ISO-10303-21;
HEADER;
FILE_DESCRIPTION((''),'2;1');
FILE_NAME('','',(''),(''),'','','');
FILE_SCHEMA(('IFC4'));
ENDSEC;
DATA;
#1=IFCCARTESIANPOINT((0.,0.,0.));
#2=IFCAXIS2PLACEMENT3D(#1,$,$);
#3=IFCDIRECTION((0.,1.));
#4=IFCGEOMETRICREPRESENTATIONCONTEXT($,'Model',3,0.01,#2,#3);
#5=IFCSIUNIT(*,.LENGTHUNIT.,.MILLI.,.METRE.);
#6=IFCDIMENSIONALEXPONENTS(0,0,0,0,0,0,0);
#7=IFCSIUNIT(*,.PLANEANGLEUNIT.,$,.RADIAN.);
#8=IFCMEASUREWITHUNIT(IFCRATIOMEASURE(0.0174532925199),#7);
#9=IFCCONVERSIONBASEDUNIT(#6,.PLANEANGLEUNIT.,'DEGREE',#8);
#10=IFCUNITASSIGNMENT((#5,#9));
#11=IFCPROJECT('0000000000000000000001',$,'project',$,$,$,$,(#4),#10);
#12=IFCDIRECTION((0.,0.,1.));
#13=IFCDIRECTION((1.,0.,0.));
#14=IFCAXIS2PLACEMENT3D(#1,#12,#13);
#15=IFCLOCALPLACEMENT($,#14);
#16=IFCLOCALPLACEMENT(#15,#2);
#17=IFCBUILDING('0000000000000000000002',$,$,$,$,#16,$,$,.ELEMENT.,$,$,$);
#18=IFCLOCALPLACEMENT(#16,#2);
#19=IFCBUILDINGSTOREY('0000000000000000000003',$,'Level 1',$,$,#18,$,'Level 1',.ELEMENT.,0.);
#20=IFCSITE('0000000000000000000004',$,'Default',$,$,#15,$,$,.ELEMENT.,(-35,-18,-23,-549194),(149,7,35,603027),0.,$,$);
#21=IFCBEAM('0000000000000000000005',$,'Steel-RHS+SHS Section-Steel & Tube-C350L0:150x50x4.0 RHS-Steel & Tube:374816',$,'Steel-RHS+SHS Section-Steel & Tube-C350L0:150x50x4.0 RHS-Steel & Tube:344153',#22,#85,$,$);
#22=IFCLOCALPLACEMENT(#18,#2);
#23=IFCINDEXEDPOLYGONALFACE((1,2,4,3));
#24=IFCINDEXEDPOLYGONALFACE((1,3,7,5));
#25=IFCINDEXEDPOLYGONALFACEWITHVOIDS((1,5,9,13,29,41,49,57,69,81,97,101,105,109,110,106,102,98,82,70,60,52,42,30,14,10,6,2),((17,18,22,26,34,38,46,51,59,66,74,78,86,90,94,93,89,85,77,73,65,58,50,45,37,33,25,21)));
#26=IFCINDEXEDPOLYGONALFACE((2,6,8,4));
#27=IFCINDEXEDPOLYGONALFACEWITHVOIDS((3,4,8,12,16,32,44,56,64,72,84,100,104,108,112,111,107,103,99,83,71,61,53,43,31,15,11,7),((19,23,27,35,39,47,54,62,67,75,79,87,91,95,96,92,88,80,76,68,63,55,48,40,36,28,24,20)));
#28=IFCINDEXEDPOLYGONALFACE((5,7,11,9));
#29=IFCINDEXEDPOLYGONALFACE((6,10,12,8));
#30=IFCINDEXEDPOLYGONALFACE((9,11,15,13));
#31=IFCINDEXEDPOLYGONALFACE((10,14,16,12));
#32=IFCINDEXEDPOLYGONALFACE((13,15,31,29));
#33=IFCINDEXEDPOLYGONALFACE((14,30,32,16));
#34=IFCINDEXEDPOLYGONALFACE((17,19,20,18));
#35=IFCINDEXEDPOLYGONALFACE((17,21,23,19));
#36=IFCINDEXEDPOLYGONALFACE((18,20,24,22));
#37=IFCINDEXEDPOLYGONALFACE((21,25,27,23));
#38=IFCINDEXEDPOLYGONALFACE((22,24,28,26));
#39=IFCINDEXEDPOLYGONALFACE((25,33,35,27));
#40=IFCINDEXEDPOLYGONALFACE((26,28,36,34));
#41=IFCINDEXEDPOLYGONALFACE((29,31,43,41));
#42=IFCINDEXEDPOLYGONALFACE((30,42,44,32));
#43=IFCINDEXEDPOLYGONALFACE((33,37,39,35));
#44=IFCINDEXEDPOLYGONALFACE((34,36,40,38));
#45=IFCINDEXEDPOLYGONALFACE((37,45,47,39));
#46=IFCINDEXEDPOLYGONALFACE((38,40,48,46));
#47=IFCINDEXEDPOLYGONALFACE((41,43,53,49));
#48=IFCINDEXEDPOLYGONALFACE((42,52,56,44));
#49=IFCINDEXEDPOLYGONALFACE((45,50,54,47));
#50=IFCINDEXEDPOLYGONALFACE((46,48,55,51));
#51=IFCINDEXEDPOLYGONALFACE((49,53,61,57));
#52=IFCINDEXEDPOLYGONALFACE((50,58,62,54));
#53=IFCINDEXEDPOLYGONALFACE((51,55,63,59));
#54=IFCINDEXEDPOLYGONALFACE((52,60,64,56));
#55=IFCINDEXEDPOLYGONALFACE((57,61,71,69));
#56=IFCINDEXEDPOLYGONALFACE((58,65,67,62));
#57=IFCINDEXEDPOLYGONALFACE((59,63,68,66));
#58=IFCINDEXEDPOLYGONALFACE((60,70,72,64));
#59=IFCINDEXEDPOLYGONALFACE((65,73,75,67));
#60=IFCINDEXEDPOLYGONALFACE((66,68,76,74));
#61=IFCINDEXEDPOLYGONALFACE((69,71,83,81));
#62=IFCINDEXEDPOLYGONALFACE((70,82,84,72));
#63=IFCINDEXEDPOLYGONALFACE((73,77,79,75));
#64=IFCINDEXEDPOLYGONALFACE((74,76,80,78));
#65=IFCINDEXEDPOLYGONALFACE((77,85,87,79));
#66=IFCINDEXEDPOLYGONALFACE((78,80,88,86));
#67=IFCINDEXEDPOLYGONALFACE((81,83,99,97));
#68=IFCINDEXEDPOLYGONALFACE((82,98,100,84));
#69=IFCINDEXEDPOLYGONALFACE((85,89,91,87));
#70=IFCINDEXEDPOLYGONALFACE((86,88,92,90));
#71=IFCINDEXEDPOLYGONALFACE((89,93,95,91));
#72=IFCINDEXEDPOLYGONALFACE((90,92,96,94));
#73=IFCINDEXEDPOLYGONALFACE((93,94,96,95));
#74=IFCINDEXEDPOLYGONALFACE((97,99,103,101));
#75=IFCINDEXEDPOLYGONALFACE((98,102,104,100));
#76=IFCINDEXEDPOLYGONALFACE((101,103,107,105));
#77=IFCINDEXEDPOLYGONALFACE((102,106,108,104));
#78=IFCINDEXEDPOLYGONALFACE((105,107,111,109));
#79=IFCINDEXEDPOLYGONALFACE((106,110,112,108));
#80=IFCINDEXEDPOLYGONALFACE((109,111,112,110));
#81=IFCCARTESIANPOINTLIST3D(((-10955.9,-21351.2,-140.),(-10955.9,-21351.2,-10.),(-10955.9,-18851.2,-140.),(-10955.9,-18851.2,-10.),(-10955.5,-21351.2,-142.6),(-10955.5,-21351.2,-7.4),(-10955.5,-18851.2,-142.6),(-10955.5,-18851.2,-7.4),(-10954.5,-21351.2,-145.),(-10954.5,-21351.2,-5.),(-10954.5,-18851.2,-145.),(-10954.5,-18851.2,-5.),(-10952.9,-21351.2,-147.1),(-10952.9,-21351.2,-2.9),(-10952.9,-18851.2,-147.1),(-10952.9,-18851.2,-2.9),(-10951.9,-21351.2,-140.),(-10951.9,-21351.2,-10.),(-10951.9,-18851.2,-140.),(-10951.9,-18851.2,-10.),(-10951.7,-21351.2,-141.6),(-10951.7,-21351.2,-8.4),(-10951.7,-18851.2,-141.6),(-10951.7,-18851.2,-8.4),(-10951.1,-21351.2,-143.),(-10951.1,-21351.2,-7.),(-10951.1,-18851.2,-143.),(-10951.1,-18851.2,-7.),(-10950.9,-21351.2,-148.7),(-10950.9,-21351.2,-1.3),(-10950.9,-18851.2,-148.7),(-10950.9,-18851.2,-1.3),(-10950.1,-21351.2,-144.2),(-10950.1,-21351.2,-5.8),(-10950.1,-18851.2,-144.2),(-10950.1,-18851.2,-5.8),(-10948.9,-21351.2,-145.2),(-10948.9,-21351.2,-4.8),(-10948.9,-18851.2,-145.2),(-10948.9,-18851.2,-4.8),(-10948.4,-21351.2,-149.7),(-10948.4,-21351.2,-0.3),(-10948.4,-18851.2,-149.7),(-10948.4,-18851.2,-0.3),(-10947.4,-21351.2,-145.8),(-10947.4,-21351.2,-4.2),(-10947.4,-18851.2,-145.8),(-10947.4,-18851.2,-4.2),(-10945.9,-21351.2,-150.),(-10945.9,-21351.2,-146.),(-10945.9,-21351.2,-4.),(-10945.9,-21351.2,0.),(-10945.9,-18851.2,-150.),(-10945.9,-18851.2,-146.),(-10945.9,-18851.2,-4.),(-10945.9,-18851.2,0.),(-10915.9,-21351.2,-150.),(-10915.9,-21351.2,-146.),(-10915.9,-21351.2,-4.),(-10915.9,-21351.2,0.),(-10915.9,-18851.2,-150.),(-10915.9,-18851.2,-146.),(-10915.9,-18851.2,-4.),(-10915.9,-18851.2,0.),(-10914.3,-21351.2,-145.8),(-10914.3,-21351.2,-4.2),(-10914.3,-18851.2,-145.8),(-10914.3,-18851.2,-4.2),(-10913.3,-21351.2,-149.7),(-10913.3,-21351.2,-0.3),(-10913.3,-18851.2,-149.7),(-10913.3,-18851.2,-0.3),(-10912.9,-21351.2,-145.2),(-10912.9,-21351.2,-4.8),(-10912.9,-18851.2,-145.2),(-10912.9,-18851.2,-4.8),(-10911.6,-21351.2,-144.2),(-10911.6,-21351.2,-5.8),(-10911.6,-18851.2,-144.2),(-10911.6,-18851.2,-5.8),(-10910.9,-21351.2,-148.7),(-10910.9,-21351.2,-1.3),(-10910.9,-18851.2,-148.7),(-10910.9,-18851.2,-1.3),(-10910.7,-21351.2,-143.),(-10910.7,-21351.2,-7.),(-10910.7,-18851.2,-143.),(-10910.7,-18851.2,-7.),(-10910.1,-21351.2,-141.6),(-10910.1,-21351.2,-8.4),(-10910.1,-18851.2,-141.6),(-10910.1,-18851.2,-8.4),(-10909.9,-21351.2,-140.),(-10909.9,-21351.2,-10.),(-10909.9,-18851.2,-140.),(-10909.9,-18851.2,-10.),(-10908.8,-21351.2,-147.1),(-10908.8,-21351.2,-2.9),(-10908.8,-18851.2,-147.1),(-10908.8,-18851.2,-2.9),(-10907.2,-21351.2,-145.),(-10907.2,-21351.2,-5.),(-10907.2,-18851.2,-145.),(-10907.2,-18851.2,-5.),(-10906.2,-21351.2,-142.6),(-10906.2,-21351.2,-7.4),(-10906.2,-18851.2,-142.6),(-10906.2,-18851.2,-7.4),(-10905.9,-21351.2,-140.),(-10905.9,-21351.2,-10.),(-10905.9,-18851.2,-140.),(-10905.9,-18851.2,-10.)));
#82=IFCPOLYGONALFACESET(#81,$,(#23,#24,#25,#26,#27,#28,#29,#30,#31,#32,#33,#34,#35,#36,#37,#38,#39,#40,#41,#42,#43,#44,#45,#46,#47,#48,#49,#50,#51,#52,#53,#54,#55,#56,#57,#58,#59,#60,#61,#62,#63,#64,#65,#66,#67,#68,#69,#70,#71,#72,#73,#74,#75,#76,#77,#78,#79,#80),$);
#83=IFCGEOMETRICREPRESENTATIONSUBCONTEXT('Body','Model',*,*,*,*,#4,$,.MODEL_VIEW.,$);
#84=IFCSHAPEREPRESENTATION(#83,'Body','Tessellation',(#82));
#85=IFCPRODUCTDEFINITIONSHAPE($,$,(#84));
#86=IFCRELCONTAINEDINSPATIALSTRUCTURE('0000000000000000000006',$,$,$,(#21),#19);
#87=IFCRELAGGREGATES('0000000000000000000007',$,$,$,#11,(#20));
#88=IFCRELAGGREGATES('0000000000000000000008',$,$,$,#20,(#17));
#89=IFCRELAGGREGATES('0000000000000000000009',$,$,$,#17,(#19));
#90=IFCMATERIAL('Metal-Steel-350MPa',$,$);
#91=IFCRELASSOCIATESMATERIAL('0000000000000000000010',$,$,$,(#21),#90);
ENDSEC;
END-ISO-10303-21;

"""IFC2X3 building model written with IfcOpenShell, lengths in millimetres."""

from ifc_helpers import new_model, entity, si_unit, converted_unit, direction, frame, frame_2d, origin, origin_with_axes, place, context, subcontext, project, spatial, polyline, circle_curve, parameter, trimmed, segment, composite_curve, outline, extrude, material, element, save


model = new_model("IFC2X3")

# Units and contexts
model_context = context("Model", 3, precision=0.01, world=origin(), true_north=direction((0.0, 1.0)))
body_context = subcontext(model_context, "Body", "Model", "MODEL_VIEW")
ifc_project = project(units=[si_unit("LENGTHUNIT", "METRE", prefix="MILLI"), converted_unit("PLANEANGLEUNIT", "DEGREE", entity("IfcRatioMeasure", 0.0174532925199), si_unit("PLANEANGLEUNIT", "RADIAN"), dimensions=[0, 0, 0, 0, 0, 0, 0])], contexts=[model_context])

# Site, building, storey
site_placement = place(None, origin_with_axes())
site = spatial("IfcSite", under=ifc_project, at=site_placement, Name="Default", CompositionType="ELEMENT", RefLatitude=(-35, -18, -23, -549194), RefLongitude=(149, 7, 35, 603027), RefElevation=0.0)
building_placement = place(site_placement, origin())
building = spatial("IfcBuilding", under=site, at=building_placement, CompositionType="ELEMENT")
storey_placement = place(building_placement, origin())
storey = spatial("IfcBuildingStorey", under=building, at=storey_placement, Name="Level 1", LongName="Level 1", CompositionType="ELEMENT", Elevation=0.0)

# Beam
ifc_material = material(Name="Metal-Steel-350MPa")
beam_1_placement = place(storey_placement, frame((-10930.9, -18851.2, 0.0), z_axis=(0.0, 0.0, 1.0), x_axis=(0.0, -1.0, 0.0)))
element("IfcBeam", 1, at=beam_1_placement, inside=storey, material=ifc_material, Name="Steel-RHS+SHS Section-Steel & Tube-C350L0:150x50x4.0 RHS-Steel & Tube:374816", ObjectType="Steel-RHS+SHS Section-Steel & Tube-C350L0:150x50x4.0 RHS-Steel & Tube:344153", context=body_context, shape_type="SweptSolid", body=[
    extrude(outline(composite_curve([segment(trimmed(circle_curve(frame_2d((-15.0, -65.0), x_axis=(1.0, 0.0)), 10.0), [parameter(180.0)], [parameter(270.0)], True, "PARAMETER"), True, "CONTINUOUS"), segment(polyline([(-15.0, -75.0), (15.0, -75.0)]), True, "CONTINUOUS"), segment(trimmed(circle_curve(frame_2d((15.0, -65.0), x_axis=(1.0, 0.0)), 10.0), [parameter(270.0)], [parameter(0.0)], True, "PARAMETER"), True, "CONTINUOUS"), segment(polyline([(25.0, -65.0), (25.0, 65.0)]), True, "CONTINUOUS"), segment(trimmed(circle_curve(frame_2d((15.0, 65.0), x_axis=(1.0, 0.0)), 10.0), [parameter(0.0)], [parameter(90.0)], True, "PARAMETER"), True, "CONTINUOUS"), segment(polyline([(15.0, 75.0), (-15.0, 75.0)]), True, "CONTINUOUS"), segment(trimmed(circle_curve(frame_2d((-15.0, 65.0), x_axis=(1.0, 0.0)), 10.0), [parameter(90.0)], [parameter(180.0)], True, "PARAMETER"), True, "CONTINUOUS"), segment(polyline([(-25.0, 65.0), (-25.0, -65.0)]), True, "CONTINUOUS")], self_intersect=False), holes=[composite_curve([segment(polyline([(15.0, -71.0), (-15.0, -71.0)]), True, "CONTINUOUS"), segment(trimmed(circle_curve(frame_2d((-15.0, -65.0), x_axis=(1.0, 0.0)), 6.0), [parameter(180.0)], [parameter(270.0)], True, "PARAMETER"), False, "CONTINUOUS"), segment(polyline([(-21.0, -65.0), (-21.0, 65.0)]), True, "CONTINUOUS"), segment(trimmed(circle_curve(frame_2d((-15.0, 65.0), x_axis=(1.0, 0.0)), 6.0), [parameter(90.0)], [parameter(180.0)], True, "PARAMETER"), False, "CONTINUOUS"), segment(polyline([(-15.0, 71.0), (15.0, 71.0)]), True, "CONTINUOUS"), segment(trimmed(circle_curve(frame_2d((15.0, 65.0), x_axis=(1.0, 0.0)), 6.0), [parameter(360.0)], [parameter(90.0)], True, "PARAMETER"), False, "CONTINUOUS"), segment(polyline([(21.0, 65.0), (21.0, -65.0)]), True, "CONTINUOUS"), segment(trimmed(circle_curve(frame_2d((15.0, -65.0), x_axis=(1.0, 0.0)), 6.0), [parameter(270.0)], [parameter(0.0)], True, "PARAMETER"), False, "CONTINUOUS")], self_intersect=False)]), frame((0.0, 0.0, -75.0), z_axis=(1.0, 0.0, 0.0), x_axis=(0.0, -1.0, 0.0)), (0.0, 0.0, 1.0), 2500.0),
])

save(model, "model.ifc")
